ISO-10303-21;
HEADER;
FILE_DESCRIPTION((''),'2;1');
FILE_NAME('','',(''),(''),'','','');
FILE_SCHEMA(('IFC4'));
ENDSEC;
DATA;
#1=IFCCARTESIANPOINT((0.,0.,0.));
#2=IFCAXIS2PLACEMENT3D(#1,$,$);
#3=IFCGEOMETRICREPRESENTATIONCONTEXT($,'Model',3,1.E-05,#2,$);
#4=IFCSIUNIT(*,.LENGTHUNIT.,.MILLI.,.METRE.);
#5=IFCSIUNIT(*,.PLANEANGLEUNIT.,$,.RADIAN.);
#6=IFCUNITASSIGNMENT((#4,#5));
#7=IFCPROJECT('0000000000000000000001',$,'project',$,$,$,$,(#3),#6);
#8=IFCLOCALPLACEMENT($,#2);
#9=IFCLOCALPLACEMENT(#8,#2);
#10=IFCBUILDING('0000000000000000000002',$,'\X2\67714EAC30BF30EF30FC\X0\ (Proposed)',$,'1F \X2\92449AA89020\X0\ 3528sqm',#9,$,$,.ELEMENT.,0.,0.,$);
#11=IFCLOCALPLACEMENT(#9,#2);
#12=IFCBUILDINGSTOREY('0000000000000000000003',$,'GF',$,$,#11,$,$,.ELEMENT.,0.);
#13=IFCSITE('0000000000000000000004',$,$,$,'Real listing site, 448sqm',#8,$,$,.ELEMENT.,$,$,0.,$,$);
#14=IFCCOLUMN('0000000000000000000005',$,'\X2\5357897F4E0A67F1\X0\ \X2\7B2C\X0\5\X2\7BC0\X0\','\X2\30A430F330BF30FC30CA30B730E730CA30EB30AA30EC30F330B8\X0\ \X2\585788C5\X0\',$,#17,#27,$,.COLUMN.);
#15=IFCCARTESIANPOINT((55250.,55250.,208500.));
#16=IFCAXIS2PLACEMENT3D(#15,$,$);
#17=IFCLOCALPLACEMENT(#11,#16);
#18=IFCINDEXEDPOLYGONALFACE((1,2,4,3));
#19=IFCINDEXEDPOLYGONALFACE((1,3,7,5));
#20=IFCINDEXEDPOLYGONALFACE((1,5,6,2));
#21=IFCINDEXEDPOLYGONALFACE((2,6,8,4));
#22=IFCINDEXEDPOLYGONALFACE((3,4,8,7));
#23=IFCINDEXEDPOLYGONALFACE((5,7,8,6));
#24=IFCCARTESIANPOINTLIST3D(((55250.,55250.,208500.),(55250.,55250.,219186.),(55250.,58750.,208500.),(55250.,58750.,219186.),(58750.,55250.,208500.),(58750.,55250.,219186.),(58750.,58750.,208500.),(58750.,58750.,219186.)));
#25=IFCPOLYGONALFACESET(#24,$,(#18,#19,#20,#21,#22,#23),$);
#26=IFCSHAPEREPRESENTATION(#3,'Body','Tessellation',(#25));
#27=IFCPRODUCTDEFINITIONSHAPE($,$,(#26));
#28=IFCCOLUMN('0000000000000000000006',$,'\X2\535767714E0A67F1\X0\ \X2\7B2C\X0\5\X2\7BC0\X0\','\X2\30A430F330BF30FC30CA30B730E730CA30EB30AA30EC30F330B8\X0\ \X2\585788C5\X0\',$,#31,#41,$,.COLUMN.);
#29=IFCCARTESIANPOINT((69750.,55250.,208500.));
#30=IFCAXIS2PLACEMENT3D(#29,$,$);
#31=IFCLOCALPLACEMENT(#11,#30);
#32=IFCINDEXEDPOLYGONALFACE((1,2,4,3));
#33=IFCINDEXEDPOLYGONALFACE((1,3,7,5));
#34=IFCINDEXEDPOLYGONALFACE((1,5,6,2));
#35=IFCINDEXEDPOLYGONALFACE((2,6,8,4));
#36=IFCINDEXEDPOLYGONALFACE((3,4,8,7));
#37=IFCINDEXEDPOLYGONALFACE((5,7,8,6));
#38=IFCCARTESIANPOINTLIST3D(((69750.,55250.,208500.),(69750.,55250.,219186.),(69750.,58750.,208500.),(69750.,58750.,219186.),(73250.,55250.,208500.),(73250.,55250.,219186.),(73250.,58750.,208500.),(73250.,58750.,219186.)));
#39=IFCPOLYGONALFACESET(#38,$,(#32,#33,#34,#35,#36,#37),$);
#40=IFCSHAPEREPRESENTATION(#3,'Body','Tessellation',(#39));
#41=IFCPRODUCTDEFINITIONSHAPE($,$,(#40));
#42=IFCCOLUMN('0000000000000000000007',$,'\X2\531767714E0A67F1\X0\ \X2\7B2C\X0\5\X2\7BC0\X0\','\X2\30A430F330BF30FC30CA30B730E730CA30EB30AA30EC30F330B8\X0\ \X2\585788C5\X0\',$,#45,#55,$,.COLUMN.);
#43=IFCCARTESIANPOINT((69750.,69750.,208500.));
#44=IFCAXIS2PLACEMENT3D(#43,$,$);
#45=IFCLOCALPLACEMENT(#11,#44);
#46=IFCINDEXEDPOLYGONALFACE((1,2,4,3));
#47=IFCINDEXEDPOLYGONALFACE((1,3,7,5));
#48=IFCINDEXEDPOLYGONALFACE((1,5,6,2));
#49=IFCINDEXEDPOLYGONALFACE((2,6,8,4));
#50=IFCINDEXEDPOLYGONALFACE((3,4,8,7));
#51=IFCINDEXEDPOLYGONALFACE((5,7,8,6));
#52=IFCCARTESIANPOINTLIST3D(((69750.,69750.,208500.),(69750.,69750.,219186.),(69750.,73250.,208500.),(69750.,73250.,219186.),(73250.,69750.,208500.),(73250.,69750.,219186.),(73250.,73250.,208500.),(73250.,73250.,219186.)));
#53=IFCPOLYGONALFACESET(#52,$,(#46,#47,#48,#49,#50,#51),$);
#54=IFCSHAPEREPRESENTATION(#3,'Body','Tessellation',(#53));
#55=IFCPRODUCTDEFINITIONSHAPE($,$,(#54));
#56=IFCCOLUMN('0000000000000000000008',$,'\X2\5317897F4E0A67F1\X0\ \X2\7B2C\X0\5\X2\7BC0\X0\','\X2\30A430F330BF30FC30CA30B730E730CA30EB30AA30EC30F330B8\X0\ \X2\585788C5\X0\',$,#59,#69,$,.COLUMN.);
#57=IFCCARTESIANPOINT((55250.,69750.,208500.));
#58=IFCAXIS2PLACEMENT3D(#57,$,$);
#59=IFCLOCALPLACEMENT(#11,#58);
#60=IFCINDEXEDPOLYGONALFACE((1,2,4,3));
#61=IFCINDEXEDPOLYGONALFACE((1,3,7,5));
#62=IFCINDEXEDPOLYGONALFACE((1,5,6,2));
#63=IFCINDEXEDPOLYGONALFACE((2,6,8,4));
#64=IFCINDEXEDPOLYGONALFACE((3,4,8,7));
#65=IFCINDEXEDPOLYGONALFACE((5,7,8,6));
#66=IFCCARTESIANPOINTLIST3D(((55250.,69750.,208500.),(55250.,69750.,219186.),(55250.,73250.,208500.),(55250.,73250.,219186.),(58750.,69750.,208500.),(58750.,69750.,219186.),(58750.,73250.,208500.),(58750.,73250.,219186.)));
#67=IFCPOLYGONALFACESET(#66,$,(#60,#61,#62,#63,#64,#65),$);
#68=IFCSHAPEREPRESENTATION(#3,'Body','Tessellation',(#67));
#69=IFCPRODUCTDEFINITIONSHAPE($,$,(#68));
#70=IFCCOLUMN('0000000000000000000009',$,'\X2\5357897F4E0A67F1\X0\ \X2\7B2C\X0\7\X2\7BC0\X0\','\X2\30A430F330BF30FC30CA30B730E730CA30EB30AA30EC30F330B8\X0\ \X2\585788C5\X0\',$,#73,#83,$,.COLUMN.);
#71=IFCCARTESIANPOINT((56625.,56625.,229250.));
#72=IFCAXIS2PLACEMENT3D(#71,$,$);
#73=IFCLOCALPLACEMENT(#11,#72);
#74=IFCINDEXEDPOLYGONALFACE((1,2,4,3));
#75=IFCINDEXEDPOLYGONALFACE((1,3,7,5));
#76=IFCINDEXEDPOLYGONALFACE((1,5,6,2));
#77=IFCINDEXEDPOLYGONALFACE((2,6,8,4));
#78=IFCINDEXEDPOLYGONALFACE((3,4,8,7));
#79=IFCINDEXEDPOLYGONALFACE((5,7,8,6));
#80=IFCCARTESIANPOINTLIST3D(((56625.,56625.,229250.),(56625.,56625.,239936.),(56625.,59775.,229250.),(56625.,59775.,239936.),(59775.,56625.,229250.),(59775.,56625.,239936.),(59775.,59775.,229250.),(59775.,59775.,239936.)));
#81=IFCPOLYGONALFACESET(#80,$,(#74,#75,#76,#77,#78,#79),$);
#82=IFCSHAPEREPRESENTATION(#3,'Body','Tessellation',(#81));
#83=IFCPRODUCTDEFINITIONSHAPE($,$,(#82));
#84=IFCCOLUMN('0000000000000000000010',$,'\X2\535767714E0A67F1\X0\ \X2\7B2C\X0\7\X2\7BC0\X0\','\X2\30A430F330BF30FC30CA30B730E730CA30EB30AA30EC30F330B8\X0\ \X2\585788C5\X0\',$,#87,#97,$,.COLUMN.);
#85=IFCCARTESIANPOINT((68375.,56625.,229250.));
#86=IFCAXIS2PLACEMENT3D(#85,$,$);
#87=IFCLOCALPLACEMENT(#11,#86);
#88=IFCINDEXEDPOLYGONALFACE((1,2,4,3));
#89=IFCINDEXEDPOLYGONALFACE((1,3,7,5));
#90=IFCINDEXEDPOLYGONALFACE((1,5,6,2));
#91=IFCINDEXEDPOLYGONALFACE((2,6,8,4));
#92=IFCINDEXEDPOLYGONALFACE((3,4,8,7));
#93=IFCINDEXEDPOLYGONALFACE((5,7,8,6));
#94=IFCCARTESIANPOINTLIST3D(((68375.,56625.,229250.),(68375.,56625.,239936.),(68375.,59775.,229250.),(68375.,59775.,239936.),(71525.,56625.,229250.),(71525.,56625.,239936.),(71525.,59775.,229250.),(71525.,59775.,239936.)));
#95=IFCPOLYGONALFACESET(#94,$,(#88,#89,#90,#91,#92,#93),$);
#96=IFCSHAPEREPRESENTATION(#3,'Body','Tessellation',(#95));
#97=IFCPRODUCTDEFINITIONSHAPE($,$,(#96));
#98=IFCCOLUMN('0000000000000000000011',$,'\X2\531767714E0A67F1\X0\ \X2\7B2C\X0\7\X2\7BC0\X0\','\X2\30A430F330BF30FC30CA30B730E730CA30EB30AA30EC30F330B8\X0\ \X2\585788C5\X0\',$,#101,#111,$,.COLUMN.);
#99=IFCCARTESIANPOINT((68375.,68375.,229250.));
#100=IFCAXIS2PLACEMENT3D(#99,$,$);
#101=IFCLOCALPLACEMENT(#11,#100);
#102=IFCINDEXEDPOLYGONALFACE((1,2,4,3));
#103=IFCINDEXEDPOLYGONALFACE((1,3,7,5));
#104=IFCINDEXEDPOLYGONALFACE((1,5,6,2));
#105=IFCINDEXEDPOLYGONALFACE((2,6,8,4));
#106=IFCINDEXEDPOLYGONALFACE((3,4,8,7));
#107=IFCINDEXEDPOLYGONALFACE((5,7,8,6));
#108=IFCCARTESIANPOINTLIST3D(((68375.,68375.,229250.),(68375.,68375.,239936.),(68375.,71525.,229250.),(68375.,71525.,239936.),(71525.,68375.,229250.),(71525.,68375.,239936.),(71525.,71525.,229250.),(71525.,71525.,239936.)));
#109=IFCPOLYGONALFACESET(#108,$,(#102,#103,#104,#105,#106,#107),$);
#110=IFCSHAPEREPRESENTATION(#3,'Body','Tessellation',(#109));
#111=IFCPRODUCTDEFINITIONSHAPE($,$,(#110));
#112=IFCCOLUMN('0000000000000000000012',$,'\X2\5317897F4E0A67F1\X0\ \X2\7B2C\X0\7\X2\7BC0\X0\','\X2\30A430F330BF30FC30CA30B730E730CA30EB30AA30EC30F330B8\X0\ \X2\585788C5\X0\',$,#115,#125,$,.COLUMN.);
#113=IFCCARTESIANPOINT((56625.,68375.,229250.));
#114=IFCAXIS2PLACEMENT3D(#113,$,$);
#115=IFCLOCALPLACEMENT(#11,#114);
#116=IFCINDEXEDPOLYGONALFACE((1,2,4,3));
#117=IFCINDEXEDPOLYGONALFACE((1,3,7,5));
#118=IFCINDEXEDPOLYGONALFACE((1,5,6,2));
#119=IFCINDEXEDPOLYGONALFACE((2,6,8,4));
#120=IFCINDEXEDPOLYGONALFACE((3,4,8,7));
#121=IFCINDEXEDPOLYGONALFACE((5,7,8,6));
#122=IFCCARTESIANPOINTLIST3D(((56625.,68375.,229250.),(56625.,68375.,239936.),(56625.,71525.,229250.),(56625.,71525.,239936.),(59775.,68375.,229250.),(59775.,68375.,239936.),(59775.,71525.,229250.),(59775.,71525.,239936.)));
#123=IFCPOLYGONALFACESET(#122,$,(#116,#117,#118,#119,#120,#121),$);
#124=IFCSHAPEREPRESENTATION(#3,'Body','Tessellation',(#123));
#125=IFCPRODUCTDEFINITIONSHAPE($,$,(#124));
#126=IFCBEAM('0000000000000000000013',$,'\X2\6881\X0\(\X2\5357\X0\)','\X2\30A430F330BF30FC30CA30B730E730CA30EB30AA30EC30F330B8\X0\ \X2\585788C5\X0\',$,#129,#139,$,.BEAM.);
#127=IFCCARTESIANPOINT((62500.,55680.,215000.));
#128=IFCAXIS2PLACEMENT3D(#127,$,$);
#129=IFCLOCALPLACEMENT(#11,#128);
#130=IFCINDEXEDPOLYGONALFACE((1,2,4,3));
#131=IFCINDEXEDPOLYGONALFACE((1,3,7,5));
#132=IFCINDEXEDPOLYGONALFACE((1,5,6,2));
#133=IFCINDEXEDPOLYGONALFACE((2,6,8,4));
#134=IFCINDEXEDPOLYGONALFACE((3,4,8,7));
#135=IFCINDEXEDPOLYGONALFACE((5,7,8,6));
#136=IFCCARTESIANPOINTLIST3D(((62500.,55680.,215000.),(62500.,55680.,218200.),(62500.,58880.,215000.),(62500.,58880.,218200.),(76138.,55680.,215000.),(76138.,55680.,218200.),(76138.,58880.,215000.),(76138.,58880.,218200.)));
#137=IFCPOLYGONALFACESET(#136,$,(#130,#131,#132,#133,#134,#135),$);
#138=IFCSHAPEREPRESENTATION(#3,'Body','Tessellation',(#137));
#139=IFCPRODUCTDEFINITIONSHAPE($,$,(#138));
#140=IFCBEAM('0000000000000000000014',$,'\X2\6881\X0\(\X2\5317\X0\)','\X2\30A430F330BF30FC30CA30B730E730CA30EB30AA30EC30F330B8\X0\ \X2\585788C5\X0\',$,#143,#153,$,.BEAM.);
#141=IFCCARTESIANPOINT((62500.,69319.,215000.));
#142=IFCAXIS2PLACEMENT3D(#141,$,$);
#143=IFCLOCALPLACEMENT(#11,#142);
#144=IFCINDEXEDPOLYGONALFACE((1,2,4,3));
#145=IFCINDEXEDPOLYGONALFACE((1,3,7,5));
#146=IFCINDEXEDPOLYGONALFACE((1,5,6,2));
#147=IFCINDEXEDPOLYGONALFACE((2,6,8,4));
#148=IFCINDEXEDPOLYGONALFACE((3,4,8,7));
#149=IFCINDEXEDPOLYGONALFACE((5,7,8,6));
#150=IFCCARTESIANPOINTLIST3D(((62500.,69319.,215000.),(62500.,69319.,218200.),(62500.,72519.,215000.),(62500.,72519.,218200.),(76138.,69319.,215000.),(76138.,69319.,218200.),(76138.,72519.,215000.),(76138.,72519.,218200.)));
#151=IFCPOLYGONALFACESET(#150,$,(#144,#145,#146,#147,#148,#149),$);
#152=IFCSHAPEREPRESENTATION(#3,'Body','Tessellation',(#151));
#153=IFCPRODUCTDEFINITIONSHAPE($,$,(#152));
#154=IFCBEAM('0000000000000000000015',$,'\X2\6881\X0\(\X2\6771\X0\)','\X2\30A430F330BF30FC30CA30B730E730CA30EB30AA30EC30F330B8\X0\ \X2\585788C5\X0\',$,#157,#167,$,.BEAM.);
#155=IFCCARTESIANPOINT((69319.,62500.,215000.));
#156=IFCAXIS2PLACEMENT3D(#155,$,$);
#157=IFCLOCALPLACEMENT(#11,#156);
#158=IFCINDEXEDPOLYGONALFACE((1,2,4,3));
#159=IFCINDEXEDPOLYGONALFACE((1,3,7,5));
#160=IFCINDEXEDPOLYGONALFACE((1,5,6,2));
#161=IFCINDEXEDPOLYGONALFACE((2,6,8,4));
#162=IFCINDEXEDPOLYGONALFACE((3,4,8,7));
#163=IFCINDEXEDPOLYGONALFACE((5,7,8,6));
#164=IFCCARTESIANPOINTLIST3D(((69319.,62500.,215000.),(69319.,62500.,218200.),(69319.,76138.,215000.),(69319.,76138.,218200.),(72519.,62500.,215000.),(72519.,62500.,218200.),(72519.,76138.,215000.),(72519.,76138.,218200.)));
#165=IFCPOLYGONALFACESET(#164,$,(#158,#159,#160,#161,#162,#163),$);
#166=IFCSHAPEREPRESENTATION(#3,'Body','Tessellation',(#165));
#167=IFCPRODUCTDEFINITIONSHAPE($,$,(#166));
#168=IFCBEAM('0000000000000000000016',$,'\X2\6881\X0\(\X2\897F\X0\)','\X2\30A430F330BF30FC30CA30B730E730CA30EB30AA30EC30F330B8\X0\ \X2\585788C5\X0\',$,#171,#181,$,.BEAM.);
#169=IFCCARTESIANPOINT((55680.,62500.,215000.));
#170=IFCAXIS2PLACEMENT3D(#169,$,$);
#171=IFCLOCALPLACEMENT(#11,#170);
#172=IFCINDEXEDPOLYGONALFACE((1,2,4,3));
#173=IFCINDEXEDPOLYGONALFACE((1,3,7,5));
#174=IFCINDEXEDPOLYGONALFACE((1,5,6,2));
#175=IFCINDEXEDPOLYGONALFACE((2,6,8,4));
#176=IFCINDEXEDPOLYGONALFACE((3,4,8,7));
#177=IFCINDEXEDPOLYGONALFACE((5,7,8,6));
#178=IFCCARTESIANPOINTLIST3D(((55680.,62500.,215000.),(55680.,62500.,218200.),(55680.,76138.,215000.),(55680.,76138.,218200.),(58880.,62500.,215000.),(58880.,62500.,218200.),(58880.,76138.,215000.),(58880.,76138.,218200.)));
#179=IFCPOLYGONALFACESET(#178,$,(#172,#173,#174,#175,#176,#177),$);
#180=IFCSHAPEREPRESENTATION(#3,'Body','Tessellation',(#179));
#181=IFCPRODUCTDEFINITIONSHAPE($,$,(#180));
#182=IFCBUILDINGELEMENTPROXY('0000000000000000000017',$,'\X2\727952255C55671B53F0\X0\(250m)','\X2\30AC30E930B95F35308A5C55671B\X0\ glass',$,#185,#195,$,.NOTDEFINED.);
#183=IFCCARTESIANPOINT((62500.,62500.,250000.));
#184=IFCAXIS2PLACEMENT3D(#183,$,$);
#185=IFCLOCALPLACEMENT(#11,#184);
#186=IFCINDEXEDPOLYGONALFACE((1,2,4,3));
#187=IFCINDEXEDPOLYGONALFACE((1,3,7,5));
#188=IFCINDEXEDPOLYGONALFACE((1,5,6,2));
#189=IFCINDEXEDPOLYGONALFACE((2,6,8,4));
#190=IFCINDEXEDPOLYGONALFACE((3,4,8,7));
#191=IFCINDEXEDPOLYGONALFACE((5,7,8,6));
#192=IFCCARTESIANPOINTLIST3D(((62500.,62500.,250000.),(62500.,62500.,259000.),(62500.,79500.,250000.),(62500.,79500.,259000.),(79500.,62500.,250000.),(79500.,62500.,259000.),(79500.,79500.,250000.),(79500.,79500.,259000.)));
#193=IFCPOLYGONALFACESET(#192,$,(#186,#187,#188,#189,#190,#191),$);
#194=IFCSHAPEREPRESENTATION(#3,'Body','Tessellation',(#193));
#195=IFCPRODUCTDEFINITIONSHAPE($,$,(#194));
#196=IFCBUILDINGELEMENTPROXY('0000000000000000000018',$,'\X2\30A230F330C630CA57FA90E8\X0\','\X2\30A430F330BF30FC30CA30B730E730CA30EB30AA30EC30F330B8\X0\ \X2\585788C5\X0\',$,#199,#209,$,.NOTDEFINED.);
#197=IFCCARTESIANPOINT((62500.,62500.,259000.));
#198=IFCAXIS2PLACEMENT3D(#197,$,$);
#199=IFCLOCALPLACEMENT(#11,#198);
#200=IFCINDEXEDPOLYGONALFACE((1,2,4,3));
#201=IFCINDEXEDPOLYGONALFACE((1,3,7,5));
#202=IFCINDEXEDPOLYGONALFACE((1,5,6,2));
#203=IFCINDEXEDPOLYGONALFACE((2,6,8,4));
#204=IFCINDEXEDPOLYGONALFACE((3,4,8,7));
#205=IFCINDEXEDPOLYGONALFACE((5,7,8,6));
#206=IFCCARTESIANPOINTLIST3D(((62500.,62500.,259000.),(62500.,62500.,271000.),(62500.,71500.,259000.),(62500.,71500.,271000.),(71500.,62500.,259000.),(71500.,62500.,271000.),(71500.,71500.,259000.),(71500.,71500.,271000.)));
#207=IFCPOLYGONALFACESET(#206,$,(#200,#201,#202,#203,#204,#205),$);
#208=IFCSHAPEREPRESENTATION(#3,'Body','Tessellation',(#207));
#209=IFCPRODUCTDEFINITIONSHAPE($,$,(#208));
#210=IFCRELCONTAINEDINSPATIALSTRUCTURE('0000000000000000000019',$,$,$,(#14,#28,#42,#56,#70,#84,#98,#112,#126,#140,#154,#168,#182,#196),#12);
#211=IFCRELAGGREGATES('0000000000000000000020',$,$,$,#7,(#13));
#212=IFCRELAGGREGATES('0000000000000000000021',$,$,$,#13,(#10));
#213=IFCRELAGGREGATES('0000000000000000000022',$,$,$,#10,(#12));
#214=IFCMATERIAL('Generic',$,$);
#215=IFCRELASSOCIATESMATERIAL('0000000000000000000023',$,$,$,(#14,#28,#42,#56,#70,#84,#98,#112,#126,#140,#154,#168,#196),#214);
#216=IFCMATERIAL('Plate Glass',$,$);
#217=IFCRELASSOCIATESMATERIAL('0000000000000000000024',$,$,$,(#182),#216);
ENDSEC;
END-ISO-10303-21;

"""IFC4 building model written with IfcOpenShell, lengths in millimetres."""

from ifc_helpers import new_model, si_unit, frame, frame_2d, origin, place, context, project, spatial, rectangle, extrude, material, element, save


model = new_model("IFC4")

# Units and contexts
model_context = context("Model", 3, precision=1e-05, world=origin())
ifc_project = project(units=[si_unit("LENGTHUNIT", "METRE", prefix="MILLI"), si_unit("PLANEANGLEUNIT", "RADIAN")], contexts=[model_context])

# Site, building, storey
site_placement = place(None, origin())
site = spatial("IfcSite", under=ifc_project, at=site_placement, ObjectType="Real listing site, 448sqm", CompositionType="ELEMENT", RefElevation=0.0)
building_placement = place(site_placement, origin())
building = spatial("IfcBuilding", under=site, at=building_placement, Name="東京タワー (Proposed)", ObjectType="1F 鉄骨造 3528sqm", CompositionType="ELEMENT", ElevationOfRefHeight=0.0, ElevationOfTerrain=0.0)
storey_placement = place(building_placement, origin())
storey = spatial("IfcBuildingStorey", under=building, at=storey_placement, Name="GF", CompositionType="ELEMENT", Elevation=0.0)

# Columns
ifc_material_1 = material(Name="Generic")
column_1_placement = place(storey_placement, frame((55250.0, 55250.0, 208500.0)))
element("IfcColumn", 1, at=column_1_placement, inside=storey, material=ifc_material_1, Name="南西上柱 第5節", Description="インターナショナルオレンジ 塗装", PredefinedType="COLUMN", context=model_context, shape_type="SweptSolid", body=[
    extrude(rectangle(XDim=3500.0, YDim=3500.0, at=frame_2d((1750.0, 1750.0))), frame((55250.0, 55250.0, 208500.0)), (0.0, 0.0, 1.0), 10686.0),
])
column_2_placement = place(storey_placement, frame((69750.0, 55250.0, 208500.0)))
element("IfcColumn", 2, at=column_2_placement, inside=storey, material=ifc_material_1, Name="南東上柱 第5節", Description="インターナショナルオレンジ 塗装", PredefinedType="COLUMN", context=model_context, shape_type="SweptSolid", body=[
    extrude(rectangle(XDim=3500.0, YDim=3500.0, at=frame_2d((1750.0, 1750.0))), frame((69750.0, 55250.0, 208500.0)), (0.0, 0.0, 1.0), 10686.0),
])
column_3_placement = place(storey_placement, frame((69750.0, 69750.0, 208500.0)))
element("IfcColumn", 3, at=column_3_placement, inside=storey, material=ifc_material_1, Name="北東上柱 第5節", Description="インターナショナルオレンジ 塗装", PredefinedType="COLUMN", context=model_context, shape_type="SweptSolid", body=[
    extrude(rectangle(XDim=3500.0, YDim=3500.0, at=frame_2d((1750.0, 1750.0))), frame((69750.0, 69750.0, 208500.0)), (0.0, 0.0, 1.0), 10686.0),
])
column_4_placement = place(storey_placement, frame((55250.0, 69750.0, 208500.0)))
element("IfcColumn", 4, at=column_4_placement, inside=storey, material=ifc_material_1, Name="北西上柱 第5節", Description="インターナショナルオレンジ 塗装", PredefinedType="COLUMN", context=model_context, shape_type="SweptSolid", body=[
    extrude(rectangle(XDim=3500.0, YDim=3500.0, at=frame_2d((1750.0, 1750.0))), frame((55250.0, 69750.0, 208500.0)), (0.0, 0.0, 1.0), 10686.0),
])
column_5_placement = place(storey_placement, frame((56625.0, 56625.0, 229250.0)))
element("IfcColumn", 5, at=column_5_placement, inside=storey, material=ifc_material_1, Name="南西上柱 第7節", Description="インターナショナルオレンジ 塗装", PredefinedType="COLUMN", context=model_context, shape_type="SweptSolid", body=[
    extrude(rectangle(XDim=3150.0, YDim=3150.0, at=frame_2d((1575.0, 1575.0))), frame((56625.0, 56625.0, 229250.0)), (0.0, 0.0, 1.0), 10686.0),
])
column_6_placement = place(storey_placement, frame((68375.0, 56625.0, 229250.0)))
element("IfcColumn", 6, at=column_6_placement, inside=storey, material=ifc_material_1, Name="南東上柱 第7節", Description="インターナショナルオレンジ 塗装", PredefinedType="COLUMN", context=model_context, shape_type="SweptSolid", body=[
    extrude(rectangle(XDim=3150.0, YDim=3150.0, at=frame_2d((1575.0, 1575.0))), frame((68375.0, 56625.0, 229250.0)), (0.0, 0.0, 1.0), 10686.0),
])
column_7_placement = place(storey_placement, frame((68375.0, 68375.0, 229250.0)))
element("IfcColumn", 7, at=column_7_placement, inside=storey, material=ifc_material_1, Name="北東上柱 第7節", Description="インターナショナルオレンジ 塗装", PredefinedType="COLUMN", context=model_context, shape_type="SweptSolid", body=[
    extrude(rectangle(XDim=3150.0, YDim=3150.0, at=frame_2d((1575.0, 1575.0))), frame((68375.0, 68375.0, 229250.0)), (0.0, 0.0, 1.0), 10686.0),
])
column_8_placement = place(storey_placement, frame((56625.0, 68375.0, 229250.0)))
element("IfcColumn", 8, at=column_8_placement, inside=storey, material=ifc_material_1, Name="北西上柱 第7節", Description="インターナショナルオレンジ 塗装", PredefinedType="COLUMN", context=model_context, shape_type="SweptSolid", body=[
    extrude(rectangle(XDim=3150.0, YDim=3150.0, at=frame_2d((1575.0, 1575.0))), frame((56625.0, 68375.0, 229250.0)), (0.0, 0.0, 1.0), 10686.0),
])

# Beams
beam_1_placement = place(storey_placement, frame((62500.0, 55680.0, 215000.0)))
element("IfcBeam", 9, at=beam_1_placement, inside=storey, material=ifc_material_1, Name="梁(南)", Description="インターナショナルオレンジ 塗装", PredefinedType="BEAM", context=model_context, shape_type="SweptSolid", body=[
    extrude(rectangle(XDim=13638.0, YDim=3200.0, at=frame_2d((6819.0, 1600.0))), frame((62500.0, 55680.0, 215000.0)), (0.0, 0.0, 1.0), 3200.0),
])
beam_2_placement = place(storey_placement, frame((62500.0, 69319.0, 215000.0)))
element("IfcBeam", 10, at=beam_2_placement, inside=storey, material=ifc_material_1, Name="梁(北)", Description="インターナショナルオレンジ 塗装", PredefinedType="BEAM", context=model_context, shape_type="SweptSolid", body=[
    extrude(rectangle(XDim=13638.0, YDim=3200.0, at=frame_2d((6819.0, 1600.0))), frame((62500.0, 69319.0, 215000.0)), (0.0, 0.0, 1.0), 3200.0),
])
beam_3_placement = place(storey_placement, frame((69319.0, 62500.0, 215000.0)))
element("IfcBeam", 11, at=beam_3_placement, inside=storey, material=ifc_material_1, Name="梁(東)", Description="インターナショナルオレンジ 塗装", PredefinedType="BEAM", context=model_context, shape_type="SweptSolid", body=[
    extrude(rectangle(XDim=3200.0, YDim=13638.0, at=frame_2d((1600.0, 6819.0))), frame((69319.0, 62500.0, 215000.0)), (0.0, 0.0, 1.0), 3200.0),
])
beam_4_placement = place(storey_placement, frame((55680.0, 62500.0, 215000.0)))
element("IfcBeam", 12, at=beam_4_placement, inside=storey, material=ifc_material_1, Name="梁(西)", Description="インターナショナルオレンジ 塗装", PredefinedType="BEAM", context=model_context, shape_type="SweptSolid", body=[
    extrude(rectangle(XDim=3200.0, YDim=13638.0, at=frame_2d((1600.0, 6819.0))), frame((55680.0, 62500.0, 215000.0)), (0.0, 0.0, 1.0), 3200.0),
])

# Building element proxies
ifc_material_2 = material(Name="Plate Glass")
proxy_1_placement = place(storey_placement, frame((62500.0, 62500.0, 250000.0)))
element("IfcBuildingElementProxy", 13, at=proxy_1_placement, inside=storey, material=ifc_material_2, Name="特別展望台(250m)", Description="ガラス張り展望 glass", PredefinedType="NOTDEFINED", context=model_context, shape_type="SweptSolid", body=[
    extrude(rectangle(XDim=17000.0, YDim=17000.0, at=frame_2d((8500.0, 8500.0))), frame((62500.0, 62500.0, 250000.0)), (0.0, 0.0, 1.0), 9000.0),
])
proxy_2_placement = place(storey_placement, frame((62500.0, 62500.0, 259000.0)))
element("IfcBuildingElementProxy", 14, at=proxy_2_placement, inside=storey, material=ifc_material_1, Name="アンテナ基部", Description="インターナショナルオレンジ 塗装", PredefinedType="NOTDEFINED", context=model_context, shape_type="SweptSolid", body=[
    extrude(rectangle(XDim=9000.0, YDim=9000.0, at=frame_2d((4500.0, 4500.0))), frame((62500.0, 62500.0, 259000.0)), (0.0, 0.0, 1.0), 12000.0),
])

save(model, "model.ifc")
